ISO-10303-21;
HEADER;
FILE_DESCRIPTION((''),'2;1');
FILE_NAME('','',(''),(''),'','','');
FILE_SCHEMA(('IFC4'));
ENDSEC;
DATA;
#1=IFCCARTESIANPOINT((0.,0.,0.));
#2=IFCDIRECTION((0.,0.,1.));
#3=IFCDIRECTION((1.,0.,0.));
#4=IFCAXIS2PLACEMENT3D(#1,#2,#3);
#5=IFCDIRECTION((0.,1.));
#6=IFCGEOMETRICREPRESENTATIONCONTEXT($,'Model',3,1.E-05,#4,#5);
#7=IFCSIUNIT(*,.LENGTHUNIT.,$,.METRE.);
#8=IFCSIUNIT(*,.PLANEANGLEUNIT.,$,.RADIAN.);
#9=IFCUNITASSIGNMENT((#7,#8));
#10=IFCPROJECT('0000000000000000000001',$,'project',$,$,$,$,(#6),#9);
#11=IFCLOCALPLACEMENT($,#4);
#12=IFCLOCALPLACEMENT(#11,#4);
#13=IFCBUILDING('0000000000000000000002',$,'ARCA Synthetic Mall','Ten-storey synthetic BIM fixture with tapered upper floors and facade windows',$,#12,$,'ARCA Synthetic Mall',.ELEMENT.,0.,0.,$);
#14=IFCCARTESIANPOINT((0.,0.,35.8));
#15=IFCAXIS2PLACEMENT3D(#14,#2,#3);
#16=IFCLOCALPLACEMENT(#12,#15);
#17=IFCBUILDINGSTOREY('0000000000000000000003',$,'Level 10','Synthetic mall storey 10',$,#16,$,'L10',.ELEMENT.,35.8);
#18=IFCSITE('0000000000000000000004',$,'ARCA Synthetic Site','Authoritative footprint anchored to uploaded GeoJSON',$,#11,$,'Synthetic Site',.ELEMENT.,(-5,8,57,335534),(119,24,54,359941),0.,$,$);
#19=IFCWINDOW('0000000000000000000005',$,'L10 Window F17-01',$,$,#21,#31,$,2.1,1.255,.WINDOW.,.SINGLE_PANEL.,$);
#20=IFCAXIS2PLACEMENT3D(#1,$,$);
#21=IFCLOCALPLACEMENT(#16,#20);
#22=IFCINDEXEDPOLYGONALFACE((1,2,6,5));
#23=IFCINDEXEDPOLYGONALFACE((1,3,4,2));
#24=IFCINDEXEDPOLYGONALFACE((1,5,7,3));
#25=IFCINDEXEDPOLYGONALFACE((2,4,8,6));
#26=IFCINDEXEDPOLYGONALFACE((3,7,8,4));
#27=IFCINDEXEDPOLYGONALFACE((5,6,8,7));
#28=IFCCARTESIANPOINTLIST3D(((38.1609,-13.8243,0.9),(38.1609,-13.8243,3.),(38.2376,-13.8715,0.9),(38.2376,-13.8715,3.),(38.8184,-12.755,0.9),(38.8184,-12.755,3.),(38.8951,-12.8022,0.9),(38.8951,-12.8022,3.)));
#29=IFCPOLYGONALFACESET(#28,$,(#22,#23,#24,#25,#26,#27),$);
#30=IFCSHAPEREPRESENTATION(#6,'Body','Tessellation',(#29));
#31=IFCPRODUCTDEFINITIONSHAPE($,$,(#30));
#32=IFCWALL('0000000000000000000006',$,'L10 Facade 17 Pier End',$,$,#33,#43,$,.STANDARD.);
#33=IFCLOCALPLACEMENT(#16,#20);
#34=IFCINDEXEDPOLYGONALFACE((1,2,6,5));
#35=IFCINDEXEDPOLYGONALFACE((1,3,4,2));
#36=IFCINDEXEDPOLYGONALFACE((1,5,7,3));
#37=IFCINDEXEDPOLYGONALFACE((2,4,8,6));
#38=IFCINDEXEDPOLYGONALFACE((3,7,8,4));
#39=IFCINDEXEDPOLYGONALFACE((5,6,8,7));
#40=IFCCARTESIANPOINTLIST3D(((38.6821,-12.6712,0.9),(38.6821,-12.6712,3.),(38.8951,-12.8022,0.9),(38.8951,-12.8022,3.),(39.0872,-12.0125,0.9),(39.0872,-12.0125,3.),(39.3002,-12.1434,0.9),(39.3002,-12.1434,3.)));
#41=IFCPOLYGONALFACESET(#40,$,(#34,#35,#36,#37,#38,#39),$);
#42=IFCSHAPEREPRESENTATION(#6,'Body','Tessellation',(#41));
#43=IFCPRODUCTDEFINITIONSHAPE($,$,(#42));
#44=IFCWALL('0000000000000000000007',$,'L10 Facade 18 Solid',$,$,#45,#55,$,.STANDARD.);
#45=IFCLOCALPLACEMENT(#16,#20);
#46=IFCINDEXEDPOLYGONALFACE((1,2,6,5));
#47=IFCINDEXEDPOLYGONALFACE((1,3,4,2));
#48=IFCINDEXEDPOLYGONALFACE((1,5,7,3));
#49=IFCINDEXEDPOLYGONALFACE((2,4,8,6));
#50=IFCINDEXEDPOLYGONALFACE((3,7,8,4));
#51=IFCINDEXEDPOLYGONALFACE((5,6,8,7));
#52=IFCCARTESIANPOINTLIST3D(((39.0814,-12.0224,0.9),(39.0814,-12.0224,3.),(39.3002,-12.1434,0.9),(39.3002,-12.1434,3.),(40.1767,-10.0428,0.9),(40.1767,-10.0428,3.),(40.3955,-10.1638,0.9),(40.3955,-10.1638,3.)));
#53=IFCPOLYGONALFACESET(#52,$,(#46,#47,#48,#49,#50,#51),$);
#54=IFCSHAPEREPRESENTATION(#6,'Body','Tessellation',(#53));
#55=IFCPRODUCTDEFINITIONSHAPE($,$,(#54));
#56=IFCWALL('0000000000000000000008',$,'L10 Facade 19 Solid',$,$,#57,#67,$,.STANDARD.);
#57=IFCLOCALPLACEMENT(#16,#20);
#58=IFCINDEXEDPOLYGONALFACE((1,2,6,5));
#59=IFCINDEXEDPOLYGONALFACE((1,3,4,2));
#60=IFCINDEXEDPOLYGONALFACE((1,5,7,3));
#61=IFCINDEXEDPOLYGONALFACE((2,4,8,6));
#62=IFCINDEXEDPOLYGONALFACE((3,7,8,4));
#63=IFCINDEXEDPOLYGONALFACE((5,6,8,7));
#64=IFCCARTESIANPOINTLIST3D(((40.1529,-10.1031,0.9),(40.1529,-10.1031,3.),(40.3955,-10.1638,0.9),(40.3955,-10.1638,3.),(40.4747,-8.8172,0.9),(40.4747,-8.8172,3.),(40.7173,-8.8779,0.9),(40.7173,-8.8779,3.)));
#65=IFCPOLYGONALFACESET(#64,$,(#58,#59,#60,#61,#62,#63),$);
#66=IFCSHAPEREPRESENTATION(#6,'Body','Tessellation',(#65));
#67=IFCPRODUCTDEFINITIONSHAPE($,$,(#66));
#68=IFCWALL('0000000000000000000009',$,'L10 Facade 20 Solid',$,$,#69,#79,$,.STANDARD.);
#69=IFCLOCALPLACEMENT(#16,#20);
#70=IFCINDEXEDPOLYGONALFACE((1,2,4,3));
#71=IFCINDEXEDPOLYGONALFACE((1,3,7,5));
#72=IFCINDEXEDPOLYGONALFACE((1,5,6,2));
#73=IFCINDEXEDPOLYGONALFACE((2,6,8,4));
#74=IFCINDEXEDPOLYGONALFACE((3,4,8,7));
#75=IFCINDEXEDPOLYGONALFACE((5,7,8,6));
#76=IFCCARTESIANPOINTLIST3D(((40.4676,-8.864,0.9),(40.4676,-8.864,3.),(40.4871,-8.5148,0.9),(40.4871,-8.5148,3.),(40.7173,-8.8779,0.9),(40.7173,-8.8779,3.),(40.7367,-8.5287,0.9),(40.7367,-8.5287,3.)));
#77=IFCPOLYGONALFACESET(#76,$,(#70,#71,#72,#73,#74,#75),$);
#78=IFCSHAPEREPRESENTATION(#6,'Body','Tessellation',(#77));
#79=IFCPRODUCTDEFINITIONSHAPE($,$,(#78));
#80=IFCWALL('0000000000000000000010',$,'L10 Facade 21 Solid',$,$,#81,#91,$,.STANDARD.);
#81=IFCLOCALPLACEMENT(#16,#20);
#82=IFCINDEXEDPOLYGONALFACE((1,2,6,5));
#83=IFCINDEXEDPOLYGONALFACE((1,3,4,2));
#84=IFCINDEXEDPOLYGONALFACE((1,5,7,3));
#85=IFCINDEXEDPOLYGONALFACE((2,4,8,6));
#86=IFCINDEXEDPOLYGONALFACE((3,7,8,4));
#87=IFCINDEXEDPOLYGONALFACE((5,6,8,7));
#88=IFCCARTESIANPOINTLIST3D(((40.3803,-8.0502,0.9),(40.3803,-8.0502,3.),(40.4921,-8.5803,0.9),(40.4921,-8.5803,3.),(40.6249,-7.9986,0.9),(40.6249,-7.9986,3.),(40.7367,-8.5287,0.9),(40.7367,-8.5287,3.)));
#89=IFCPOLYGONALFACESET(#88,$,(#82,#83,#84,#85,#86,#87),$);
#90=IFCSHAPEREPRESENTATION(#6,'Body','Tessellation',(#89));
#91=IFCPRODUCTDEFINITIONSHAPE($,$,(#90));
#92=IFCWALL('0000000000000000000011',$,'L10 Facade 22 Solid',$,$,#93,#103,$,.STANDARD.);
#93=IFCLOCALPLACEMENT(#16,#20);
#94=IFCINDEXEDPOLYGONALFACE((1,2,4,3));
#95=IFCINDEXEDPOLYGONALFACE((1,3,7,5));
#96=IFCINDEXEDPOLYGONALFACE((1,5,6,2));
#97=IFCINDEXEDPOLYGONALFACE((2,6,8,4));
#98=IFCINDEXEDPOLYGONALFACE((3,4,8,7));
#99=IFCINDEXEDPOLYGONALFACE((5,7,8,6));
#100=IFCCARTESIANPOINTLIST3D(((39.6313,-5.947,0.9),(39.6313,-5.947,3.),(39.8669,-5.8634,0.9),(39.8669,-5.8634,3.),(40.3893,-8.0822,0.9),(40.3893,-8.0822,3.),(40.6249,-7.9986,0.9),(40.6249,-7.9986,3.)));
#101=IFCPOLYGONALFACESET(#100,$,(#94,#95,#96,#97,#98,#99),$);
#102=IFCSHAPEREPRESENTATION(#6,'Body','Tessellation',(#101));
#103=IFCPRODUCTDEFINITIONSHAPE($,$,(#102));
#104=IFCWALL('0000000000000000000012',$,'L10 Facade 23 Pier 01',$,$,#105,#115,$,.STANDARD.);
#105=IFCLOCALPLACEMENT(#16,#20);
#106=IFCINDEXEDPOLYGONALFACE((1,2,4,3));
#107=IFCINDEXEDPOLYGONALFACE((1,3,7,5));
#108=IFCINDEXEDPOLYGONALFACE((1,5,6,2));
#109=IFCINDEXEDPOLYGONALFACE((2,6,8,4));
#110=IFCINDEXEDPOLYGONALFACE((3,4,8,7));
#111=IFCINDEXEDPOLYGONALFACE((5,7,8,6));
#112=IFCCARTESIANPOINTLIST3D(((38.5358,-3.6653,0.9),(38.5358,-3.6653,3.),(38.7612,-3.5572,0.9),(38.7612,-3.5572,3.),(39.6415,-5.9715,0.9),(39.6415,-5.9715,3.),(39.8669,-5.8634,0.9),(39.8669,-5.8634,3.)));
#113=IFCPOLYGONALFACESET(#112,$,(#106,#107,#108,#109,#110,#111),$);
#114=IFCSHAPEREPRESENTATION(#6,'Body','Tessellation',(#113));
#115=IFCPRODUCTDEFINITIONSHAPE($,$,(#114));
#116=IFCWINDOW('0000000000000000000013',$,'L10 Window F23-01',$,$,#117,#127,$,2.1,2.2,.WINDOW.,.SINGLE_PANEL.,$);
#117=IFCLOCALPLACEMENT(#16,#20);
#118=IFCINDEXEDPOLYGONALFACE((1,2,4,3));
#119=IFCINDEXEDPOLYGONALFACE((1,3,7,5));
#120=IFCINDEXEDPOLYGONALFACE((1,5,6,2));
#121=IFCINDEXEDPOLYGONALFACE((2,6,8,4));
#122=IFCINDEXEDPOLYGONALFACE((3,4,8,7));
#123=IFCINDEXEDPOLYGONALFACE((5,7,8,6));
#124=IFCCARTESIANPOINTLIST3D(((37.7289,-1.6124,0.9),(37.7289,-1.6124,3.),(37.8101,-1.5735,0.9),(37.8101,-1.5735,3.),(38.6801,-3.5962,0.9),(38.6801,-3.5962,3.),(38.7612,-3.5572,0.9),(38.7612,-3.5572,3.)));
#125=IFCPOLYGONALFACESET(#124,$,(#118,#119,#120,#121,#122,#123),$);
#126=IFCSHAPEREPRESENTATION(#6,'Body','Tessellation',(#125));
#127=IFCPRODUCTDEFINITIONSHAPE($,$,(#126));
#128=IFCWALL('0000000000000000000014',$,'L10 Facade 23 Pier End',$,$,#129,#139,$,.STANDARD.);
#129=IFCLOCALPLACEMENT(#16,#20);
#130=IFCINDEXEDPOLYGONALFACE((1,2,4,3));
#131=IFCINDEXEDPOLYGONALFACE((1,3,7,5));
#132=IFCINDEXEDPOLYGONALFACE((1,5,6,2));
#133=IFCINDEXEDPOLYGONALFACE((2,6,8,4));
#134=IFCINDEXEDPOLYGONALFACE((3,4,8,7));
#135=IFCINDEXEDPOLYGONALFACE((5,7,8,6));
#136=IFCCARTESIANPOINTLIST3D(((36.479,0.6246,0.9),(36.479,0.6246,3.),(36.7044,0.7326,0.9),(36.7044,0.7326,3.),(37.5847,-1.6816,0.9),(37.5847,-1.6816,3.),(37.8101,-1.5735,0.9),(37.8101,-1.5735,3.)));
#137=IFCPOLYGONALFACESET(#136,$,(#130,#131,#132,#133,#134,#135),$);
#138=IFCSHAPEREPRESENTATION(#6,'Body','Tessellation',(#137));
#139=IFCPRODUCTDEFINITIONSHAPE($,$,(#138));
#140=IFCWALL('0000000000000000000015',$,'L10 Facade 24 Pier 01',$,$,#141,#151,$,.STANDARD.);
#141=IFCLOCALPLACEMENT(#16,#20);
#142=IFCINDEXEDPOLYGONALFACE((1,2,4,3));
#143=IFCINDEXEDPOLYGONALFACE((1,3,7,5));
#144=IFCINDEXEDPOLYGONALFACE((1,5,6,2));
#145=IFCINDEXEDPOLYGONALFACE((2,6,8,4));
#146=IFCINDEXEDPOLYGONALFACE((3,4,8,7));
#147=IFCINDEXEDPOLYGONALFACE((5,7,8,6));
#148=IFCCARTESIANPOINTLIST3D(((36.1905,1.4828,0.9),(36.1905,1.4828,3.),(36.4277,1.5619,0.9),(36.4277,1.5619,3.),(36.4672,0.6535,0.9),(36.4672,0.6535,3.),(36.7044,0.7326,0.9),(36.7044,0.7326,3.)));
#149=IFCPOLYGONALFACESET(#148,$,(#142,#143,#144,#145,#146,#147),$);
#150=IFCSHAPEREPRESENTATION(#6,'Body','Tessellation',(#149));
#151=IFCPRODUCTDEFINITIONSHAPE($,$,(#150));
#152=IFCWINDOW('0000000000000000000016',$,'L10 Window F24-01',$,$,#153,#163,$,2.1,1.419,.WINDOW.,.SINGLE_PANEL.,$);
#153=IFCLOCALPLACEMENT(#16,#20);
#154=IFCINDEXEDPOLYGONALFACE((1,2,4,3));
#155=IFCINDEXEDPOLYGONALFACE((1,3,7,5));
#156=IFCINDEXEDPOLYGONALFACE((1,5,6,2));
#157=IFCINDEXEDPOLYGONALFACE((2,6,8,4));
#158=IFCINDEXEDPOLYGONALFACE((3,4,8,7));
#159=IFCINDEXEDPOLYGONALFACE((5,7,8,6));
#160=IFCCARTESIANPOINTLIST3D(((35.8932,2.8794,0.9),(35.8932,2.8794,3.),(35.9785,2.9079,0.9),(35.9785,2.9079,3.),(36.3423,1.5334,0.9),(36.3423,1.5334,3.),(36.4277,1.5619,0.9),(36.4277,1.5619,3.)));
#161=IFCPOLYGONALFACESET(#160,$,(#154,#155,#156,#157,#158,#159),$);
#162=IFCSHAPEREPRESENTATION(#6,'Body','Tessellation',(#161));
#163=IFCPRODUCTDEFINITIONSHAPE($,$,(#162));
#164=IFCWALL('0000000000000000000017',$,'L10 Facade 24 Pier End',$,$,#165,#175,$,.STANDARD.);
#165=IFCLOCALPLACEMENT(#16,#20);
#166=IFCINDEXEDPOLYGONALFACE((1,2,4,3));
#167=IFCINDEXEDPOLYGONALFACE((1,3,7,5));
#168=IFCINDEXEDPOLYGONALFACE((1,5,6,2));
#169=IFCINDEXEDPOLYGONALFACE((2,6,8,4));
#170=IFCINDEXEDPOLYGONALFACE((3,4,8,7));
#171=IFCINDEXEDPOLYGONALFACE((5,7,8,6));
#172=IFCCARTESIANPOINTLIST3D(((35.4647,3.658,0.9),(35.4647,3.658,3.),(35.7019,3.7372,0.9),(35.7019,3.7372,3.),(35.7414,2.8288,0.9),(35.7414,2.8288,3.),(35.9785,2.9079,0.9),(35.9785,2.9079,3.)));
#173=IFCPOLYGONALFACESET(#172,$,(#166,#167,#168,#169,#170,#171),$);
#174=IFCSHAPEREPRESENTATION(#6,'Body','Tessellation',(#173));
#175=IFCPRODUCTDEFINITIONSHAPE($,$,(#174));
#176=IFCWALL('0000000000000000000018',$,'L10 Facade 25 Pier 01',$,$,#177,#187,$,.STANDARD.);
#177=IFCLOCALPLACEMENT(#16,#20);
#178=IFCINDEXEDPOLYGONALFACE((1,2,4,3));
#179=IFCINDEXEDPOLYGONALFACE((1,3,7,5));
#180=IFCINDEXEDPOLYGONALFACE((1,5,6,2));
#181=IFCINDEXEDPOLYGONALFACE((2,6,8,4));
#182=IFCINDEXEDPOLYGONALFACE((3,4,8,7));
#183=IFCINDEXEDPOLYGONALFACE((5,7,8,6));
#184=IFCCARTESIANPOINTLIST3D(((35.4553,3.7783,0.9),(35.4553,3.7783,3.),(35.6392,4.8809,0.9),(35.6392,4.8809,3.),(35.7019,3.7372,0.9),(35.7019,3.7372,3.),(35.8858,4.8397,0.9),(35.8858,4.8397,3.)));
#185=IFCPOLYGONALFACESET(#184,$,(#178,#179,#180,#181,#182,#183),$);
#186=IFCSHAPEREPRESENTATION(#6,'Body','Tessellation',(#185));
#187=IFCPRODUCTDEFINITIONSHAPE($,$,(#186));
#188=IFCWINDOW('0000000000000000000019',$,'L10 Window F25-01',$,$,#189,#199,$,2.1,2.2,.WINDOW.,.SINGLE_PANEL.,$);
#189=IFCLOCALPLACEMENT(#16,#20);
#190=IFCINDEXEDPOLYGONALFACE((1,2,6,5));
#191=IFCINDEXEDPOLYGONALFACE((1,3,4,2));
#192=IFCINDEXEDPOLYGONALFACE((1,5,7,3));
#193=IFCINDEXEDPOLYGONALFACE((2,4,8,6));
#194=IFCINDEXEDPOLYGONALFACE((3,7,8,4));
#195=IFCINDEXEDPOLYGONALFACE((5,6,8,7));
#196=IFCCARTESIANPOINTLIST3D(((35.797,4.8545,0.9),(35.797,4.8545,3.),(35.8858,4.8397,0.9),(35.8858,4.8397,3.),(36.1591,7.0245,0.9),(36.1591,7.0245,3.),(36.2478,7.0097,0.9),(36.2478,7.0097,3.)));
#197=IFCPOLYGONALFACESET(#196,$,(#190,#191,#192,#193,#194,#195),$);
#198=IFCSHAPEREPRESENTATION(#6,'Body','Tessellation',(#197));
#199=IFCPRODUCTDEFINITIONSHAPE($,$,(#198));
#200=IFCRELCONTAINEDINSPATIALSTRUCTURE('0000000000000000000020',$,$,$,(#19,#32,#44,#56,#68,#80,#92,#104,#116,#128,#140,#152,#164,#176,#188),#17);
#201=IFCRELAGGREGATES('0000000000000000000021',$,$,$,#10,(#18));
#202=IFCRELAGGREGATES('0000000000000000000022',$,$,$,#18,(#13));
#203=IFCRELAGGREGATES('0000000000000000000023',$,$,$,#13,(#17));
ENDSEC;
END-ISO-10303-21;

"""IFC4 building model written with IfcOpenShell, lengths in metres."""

from ifc_helpers import new_model, si_unit, direction, frame, origin_with_axes, place, context, project, spatial, polyline, outline, extrude, element, save


model = new_model("IFC4")

# Units and contexts
model_context = context("Model", 3, precision=1e-05, world=origin_with_axes(), true_north=direction((0.0, 1.0)))
ifc_project = project(units=[si_unit("LENGTHUNIT", "METRE"), si_unit("PLANEANGLEUNIT", "RADIAN")], contexts=[model_context])

# Site, building, storey
site_placement = place(None, origin_with_axes())
site = spatial("IfcSite", under=ifc_project, at=site_placement, Name="ARCA Synthetic Site", Description="Authoritative footprint anchored to uploaded GeoJSON", LongName="Synthetic Site", CompositionType="ELEMENT", RefLatitude=(-5, 8, 57, 335534), RefLongitude=(119, 24, 54, 359941), RefElevation=0.0)
building_placement = place(site_placement, origin_with_axes())
building = spatial("IfcBuilding", under=site, at=building_placement, Name="ARCA Synthetic Mall", Description="Ten-storey synthetic BIM fixture with tapered upper floors and facade windows", LongName="ARCA Synthetic Mall", CompositionType="ELEMENT", ElevationOfRefHeight=0.0, ElevationOfTerrain=0.0)
storey_placement = place(building_placement, frame((0.0, 0.0, 35.8), z_axis=(0.0, 0.0, 1.0), x_axis=(1.0, 0.0, 0.0)))
storey = spatial("IfcBuildingStorey", under=building, at=storey_placement, Name="Level 10", Description="Synthetic mall storey 10", LongName="L10", CompositionType="ELEMENT", Elevation=35.8)

# Window
window_1_placement = place(storey_placement, frame((0.0, 0.0, 0.9), z_axis=(0.0, 0.0, 1.0), x_axis=(1.0, 0.0, 0.0)))
element("IfcWindow", 1, at=window_1_placement, inside=storey, Name="L10 Window F17-01", OverallHeight=2.1, OverallWidth=1.255, PartitioningType="SINGLE_PANEL", PredefinedType="WINDOW", context=model_context, shape_type="SweptSolid", body=[
    extrude(outline(polyline([(38.2376, -13.8715), (38.8951, -12.8022), (38.8184, -12.755), (38.1609, -13.8243), (38.2376, -13.8715)])), origin_with_axes(), (0.0, 0.0, 1.0), 2.1),
])

# Walls
wall_1_placement = place(storey_placement, frame((0.0, 0.0, 0.9), z_axis=(0.0, 0.0, 1.0), x_axis=(1.0, 0.0, 0.0)))
element("IfcWall", 2, at=wall_1_placement, inside=storey, Name="L10 Facade 17 Pier End", PredefinedType="STANDARD", context=model_context, shape_type="SweptSolid", body=[
    extrude(outline(polyline([(38.8951, -12.8022), (39.3002, -12.1434), (39.0872, -12.0125), (38.6821, -12.6712), (38.8951, -12.8022)])), origin_with_axes(), (0.0, 0.0, 1.0), 2.1),
])
wall_2_placement = place(storey_placement, frame((0.0, 0.0, 0.9), z_axis=(0.0, 0.0, 1.0), x_axis=(1.0, 0.0, 0.0)))
element("IfcWall", 3, at=wall_2_placement, inside=storey, Name="L10 Facade 18 Solid", PredefinedType="STANDARD", context=model_context, shape_type="SweptSolid", body=[
    extrude(outline(polyline([(39.3002, -12.1434), (40.3955, -10.1638), (40.1767, -10.0428), (39.0814, -12.0224), (39.3002, -12.1434)])), origin_with_axes(), (0.0, 0.0, 1.0), 2.1),
])
wall_3_placement = place(storey_placement, frame((0.0, 0.0, 0.9), z_axis=(0.0, 0.0, 1.0), x_axis=(1.0, 0.0, 0.0)))
element("IfcWall", 4, at=wall_3_placement, inside=storey, Name="L10 Facade 19 Solid", PredefinedType="STANDARD", context=model_context, shape_type="SweptSolid", body=[
    extrude(outline(polyline([(40.3955, -10.1638), (40.7173, -8.8779), (40.4747, -8.8172), (40.1529, -10.1031), (40.3955, -10.1638)])), origin_with_axes(), (0.0, 0.0, 1.0), 2.1),
])
wall_4_placement = place(storey_placement, frame((0.0, 0.0, 0.9), z_axis=(0.0, 0.0, 1.0), x_axis=(1.0, 0.0, 0.0)))
element("IfcWall", 5, at=wall_4_placement, inside=storey, Name="L10 Facade 20 Solid", PredefinedType="STANDARD", context=model_context, shape_type="SweptSolid", body=[
    extrude(outline(polyline([(40.7173, -8.8779), (40.7367, -8.5287), (40.4871, -8.5148), (40.4676, -8.864), (40.7173, -8.8779)])), origin_with_axes(), (0.0, 0.0, 1.0), 2.1),
])
wall_5_placement = place(storey_placement, frame((0.0, 0.0, 0.9), z_axis=(0.0, 0.0, 1.0), x_axis=(1.0, 0.0, 0.0)))
element("IfcWall", 6, at=wall_5_placement, inside=storey, Name="L10 Facade 21 Solid", PredefinedType="STANDARD", context=model_context, shape_type="SweptSolid", body=[
    extrude(outline(polyline([(40.7367, -8.5287), (40.6249, -7.9986), (40.3803, -8.0502), (40.4921, -8.5803), (40.7367, -8.5287)])), origin_with_axes(), (0.0, 0.0, 1.0), 2.1),
])
wall_6_placement = place(storey_placement, frame((0.0, 0.0, 0.9), z_axis=(0.0, 0.0, 1.0), x_axis=(1.0, 0.0, 0.0)))
element("IfcWall", 7, at=wall_6_placement, inside=storey, Name="L10 Facade 22 Solid", PredefinedType="STANDARD", context=model_context, shape_type="SweptSolid", body=[
    extrude(outline(polyline([(40.6249, -7.9986), (39.8669, -5.8634), (39.6313, -5.947), (40.3893, -8.0822), (40.6249, -7.9986)])), origin_with_axes(), (0.0, 0.0, 1.0), 2.1),
])
wall_7_placement = place(storey_placement, frame((0.0, 0.0, 0.9), z_axis=(0.0, 0.0, 1.0), x_axis=(1.0, 0.0, 0.0)))
element("IfcWall", 8, at=wall_7_placement, inside=storey, Name="L10 Facade 23 Pier 01", PredefinedType="STANDARD", context=model_context, shape_type="SweptSolid", body=[
    extrude(outline(polyline([(39.8669, -5.8634), (38.7612, -3.5572), (38.5358, -3.6653), (39.6415, -5.9715), (39.8669, -5.8634)])), origin_with_axes(), (0.0, 0.0, 1.0), 2.1),
])

# Window
window_2_placement = place(storey_placement, frame((0.0, 0.0, 0.9), z_axis=(0.0, 0.0, 1.0), x_axis=(1.0, 0.0, 0.0)))
element("IfcWindow", 9, at=window_2_placement, inside=storey, Name="L10 Window F23-01", OverallHeight=2.1, OverallWidth=2.2, PartitioningType="SINGLE_PANEL", PredefinedType="WINDOW", context=model_context, shape_type="SweptSolid", body=[
    extrude(outline(polyline([(38.7612, -3.5572), (37.8101, -1.5735), (37.7289, -1.6124), (38.6801, -3.5962), (38.7612, -3.5572)])), origin_with_axes(), (0.0, 0.0, 1.0), 2.1),
])

# Walls
wall_8_placement = place(storey_placement, frame((0.0, 0.0, 0.9), z_axis=(0.0, 0.0, 1.0), x_axis=(1.0, 0.0, 0.0)))
element("IfcWall", 10, at=wall_8_placement, inside=storey, Name="L10 Facade 23 Pier End", PredefinedType="STANDARD", context=model_context, shape_type="SweptSolid", body=[
    extrude(outline(polyline([(37.8101, -1.5735), (36.7044, 0.7326), (36.479, 0.6246), (37.5847, -1.6816), (37.8101, -1.5735)])), origin_with_axes(), (0.0, 0.0, 1.0), 2.1),
])
wall_9_placement = place(storey_placement, frame((0.0, 0.0, 0.9), z_axis=(0.0, 0.0, 1.0), x_axis=(1.0, 0.0, 0.0)))
element("IfcWall", 11, at=wall_9_placement, inside=storey, Name="L10 Facade 24 Pier 01", PredefinedType="STANDARD", context=model_context, shape_type="SweptSolid", body=[
    extrude(outline(polyline([(36.7044, 0.7326), (36.4277, 1.5619), (36.1905, 1.4828), (36.4672, 0.6535), (36.7044, 0.7326)])), origin_with_axes(), (0.0, 0.0, 1.0), 2.1),
])

# Window
window_3_placement = place(storey_placement, frame((0.0, 0.0, 0.9), z_axis=(0.0, 0.0, 1.0), x_axis=(1.0, 0.0, 0.0)))
element("IfcWindow", 12, at=window_3_placement, inside=storey, Name="L10 Window F24-01", OverallHeight=2.1, OverallWidth=1.419, PartitioningType="SINGLE_PANEL", PredefinedType="WINDOW", context=model_context, shape_type="SweptSolid", body=[
    extrude(outline(polyline([(36.4277, 1.5619), (35.9785, 2.9079), (35.8932, 2.8794), (36.3423, 1.5334), (36.4277, 1.5619)])), origin_with_axes(), (0.0, 0.0, 1.0), 2.1),
])

# Walls
wall_10_placement = place(storey_placement, frame((0.0, 0.0, 0.9), z_axis=(0.0, 0.0, 1.0), x_axis=(1.0, 0.0, 0.0)))
element("IfcWall", 13, at=wall_10_placement, inside=storey, Name="L10 Facade 24 Pier End", PredefinedType="STANDARD", context=model_context, shape_type="SweptSolid", body=[
    extrude(outline(polyline([(35.9785, 2.9079), (35.7019, 3.7372), (35.4647, 3.658), (35.7414, 2.8288), (35.9785, 2.9079)])), origin_with_axes(), (0.0, 0.0, 1.0), 2.1),
])
wall_11_placement = place(storey_placement, frame((0.0, 0.0, 0.9), z_axis=(0.0, 0.0, 1.0), x_axis=(1.0, 0.0, 0.0)))
element("IfcWall", 14, at=wall_11_placement, inside=storey, Name="L10 Facade 25 Pier 01", PredefinedType="STANDARD", context=model_context, shape_type="SweptSolid", body=[
    extrude(outline(polyline([(35.7019, 3.7372), (35.8858, 4.8397), (35.6392, 4.8809), (35.4553, 3.7783), (35.7019, 3.7372)])), origin_with_axes(), (0.0, 0.0, 1.0), 2.1),
])

# Window
window_4_placement = place(storey_placement, frame((0.0, 0.0, 0.9), z_axis=(0.0, 0.0, 1.0), x_axis=(1.0, 0.0, 0.0)))
element("IfcWindow", 15, at=window_4_placement, inside=storey, Name="L10 Window F25-01", OverallHeight=2.1, OverallWidth=2.2, PartitioningType="SINGLE_PANEL", PredefinedType="WINDOW", context=model_context, shape_type="SweptSolid", body=[
    extrude(outline(polyline([(35.8858, 4.8397), (36.2478, 7.0097), (36.1591, 7.0245), (35.797, 4.8545), (35.8858, 4.8397)])), origin_with_axes(), (0.0, 0.0, 1.0), 2.1),
])

save(model, "model.ifc")
